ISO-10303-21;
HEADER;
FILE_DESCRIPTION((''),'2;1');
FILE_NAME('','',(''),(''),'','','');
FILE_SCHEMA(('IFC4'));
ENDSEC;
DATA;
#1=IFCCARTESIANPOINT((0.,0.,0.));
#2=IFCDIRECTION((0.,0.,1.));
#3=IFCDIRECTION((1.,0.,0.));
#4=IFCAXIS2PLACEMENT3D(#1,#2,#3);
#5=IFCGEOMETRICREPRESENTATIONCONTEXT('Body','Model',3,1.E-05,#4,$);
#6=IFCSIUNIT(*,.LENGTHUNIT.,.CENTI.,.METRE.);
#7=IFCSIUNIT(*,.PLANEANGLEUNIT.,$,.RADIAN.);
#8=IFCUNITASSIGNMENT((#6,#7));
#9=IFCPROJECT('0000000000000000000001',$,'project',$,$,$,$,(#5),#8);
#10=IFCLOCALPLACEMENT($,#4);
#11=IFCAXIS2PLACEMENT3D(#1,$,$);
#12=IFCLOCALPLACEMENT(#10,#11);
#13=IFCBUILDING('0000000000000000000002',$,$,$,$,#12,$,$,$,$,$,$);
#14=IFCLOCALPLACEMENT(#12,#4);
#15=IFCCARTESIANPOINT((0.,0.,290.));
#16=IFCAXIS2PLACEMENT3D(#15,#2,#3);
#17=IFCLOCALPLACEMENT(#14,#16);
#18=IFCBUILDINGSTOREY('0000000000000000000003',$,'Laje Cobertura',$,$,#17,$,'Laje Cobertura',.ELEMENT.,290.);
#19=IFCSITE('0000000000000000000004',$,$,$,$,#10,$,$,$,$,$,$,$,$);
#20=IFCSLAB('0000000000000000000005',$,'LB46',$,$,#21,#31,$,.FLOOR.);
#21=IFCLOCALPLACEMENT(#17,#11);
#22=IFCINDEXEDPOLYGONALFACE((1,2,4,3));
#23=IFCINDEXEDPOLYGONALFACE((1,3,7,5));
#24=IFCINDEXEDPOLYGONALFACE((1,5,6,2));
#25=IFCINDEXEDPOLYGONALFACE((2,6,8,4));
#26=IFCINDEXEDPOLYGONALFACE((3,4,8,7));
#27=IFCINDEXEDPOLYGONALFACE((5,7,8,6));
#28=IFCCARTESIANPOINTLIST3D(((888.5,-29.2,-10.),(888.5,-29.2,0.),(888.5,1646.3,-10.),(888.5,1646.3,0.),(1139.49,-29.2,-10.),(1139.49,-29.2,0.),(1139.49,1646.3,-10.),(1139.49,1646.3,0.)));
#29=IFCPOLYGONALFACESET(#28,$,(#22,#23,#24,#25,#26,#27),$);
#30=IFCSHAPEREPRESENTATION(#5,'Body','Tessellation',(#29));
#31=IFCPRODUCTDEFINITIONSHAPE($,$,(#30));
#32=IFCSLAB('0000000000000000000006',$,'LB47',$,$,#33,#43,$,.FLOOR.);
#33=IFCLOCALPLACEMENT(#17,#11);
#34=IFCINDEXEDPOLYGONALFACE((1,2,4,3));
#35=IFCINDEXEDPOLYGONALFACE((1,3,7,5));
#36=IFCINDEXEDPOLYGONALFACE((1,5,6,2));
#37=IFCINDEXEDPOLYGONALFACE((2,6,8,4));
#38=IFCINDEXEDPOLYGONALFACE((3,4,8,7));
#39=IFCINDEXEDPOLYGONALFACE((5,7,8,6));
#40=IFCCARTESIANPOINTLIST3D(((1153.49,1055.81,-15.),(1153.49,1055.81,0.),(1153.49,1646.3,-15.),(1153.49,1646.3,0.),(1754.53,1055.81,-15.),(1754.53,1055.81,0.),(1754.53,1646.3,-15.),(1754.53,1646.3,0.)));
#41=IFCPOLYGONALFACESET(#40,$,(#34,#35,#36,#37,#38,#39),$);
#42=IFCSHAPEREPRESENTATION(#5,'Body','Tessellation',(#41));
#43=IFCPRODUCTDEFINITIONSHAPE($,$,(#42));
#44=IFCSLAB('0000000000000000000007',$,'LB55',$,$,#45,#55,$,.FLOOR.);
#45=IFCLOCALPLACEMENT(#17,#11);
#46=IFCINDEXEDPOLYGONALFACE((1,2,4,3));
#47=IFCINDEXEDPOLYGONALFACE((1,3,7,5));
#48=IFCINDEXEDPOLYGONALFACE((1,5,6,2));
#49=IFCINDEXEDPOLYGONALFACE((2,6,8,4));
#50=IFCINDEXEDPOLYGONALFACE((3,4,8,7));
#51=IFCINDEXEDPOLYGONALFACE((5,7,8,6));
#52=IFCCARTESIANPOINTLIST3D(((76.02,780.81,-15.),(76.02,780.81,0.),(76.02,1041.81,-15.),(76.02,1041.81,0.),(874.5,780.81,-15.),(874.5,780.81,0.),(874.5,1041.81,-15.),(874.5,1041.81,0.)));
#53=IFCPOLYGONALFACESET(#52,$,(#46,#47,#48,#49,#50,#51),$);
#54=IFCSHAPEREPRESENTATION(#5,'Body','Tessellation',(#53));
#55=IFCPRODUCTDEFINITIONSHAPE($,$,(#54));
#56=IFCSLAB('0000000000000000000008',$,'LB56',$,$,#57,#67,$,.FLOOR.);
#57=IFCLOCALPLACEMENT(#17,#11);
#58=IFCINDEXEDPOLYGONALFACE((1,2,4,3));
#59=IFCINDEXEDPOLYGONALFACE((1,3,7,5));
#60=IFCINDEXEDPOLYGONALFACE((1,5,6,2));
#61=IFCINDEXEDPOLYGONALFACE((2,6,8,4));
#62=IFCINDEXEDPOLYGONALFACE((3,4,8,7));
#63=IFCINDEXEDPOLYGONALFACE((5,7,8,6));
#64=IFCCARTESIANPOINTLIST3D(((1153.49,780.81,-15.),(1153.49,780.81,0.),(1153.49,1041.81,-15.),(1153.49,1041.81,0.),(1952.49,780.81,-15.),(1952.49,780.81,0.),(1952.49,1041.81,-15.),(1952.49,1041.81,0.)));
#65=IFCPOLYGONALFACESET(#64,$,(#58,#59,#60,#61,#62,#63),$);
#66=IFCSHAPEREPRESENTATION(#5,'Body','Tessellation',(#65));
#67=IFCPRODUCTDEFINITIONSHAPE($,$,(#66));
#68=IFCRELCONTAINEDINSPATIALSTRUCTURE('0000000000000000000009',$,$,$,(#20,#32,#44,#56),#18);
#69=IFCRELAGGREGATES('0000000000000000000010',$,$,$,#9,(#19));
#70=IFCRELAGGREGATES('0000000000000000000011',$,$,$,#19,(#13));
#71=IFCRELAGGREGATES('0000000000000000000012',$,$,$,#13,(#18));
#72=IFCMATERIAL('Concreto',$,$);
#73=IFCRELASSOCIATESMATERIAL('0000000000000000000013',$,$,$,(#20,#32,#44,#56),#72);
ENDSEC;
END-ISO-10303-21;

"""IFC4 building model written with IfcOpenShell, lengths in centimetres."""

from ifc_helpers import new_model, si_unit, frame, origin, origin_with_axes, place, context, project, spatial, polyline, outline, extrude, material, element, save


model = new_model("IFC4")

# Units and contexts
model_context = context("Model", 3, precision=1e-05, world=origin_with_axes(), identifier="Body")
ifc_project = project(units=[si_unit("LENGTHUNIT", "METRE", prefix="CENTI"), si_unit("PLANEANGLEUNIT", "RADIAN")], contexts=[model_context])

# Site, building, storey
site_placement = place(None, origin_with_axes())
site = spatial("IfcSite", under=ifc_project, at=site_placement)
building_placement = place(site_placement, origin())
building = spatial("IfcBuilding", under=site, at=building_placement)
placement = place(building_placement, origin_with_axes())
storey_placement = place(placement, frame((0.0, 0.0, 290.0), z_axis=(0.0, 0.0, 1.0), x_axis=(1.0, 0.0, 0.0)))
storey = spatial("IfcBuildingStorey", under=building, at=storey_placement, Name="Laje Cobertura", LongName="Laje Cobertura", CompositionType="ELEMENT", Elevation=290.0)

# Shared definitions
ifc_material = material(Name="Concreto")

# Slabs
slab_1_placement = place(storey_placement, frame((1014.0, 808.55, 0.0), z_axis=(0.0, 0.0, 1.0), x_axis=(1.0, 0.0, 0.0)))
element("IfcSlab", 1, at=slab_1_placement, inside=storey, material=ifc_material, Name="LB46", PredefinedType="FLOOR", context=model_context, shape_type="SolidModel", body=[
    extrude(outline(polyline([(125.5, 837.75), (-125.5, 837.75), (-125.49, -837.75), (125.5, -837.75), (125.5, 837.75), (125.5, 837.75)])), frame((0.0, 0.0, -10.0), z_axis=(0.0, 0.0, 1.0), x_axis=(1.0, 0.0, 0.0)), (0.0, 0.0, 1.0), 10.0),
])
slab_2_placement = place(storey_placement, frame((1454.01, 1351.05, 0.0), z_axis=(0.0, 0.0, 1.0), x_axis=(1.0, 0.0, 0.0)))
element("IfcSlab", 2, at=slab_2_placement, inside=storey, material=ifc_material, Name="LB47", PredefinedType="FLOOR", context=model_context, shape_type="SolidModel", body=[
    extrude(outline(polyline([(300.52, -295.25), (300.52, 295.24), (-300.52, 295.24), (-300.52, -295.24), (300.52, -295.25), (300.52, -295.25)])), frame((0.0, 0.0, -15.0), z_axis=(0.0, 0.0, 1.0), x_axis=(1.0, 0.0, 0.0)), (0.0, 0.0, 1.0), 15.0),
])
slab_3_placement = place(storey_placement, frame((475.26, 911.31, 0.0), z_axis=(0.0, 0.0, 1.0), x_axis=(1.0, 0.0, 0.0)))
element("IfcSlab", 3, at=slab_3_placement, inside=storey, material=ifc_material, Name="LB55", PredefinedType="FLOOR", context=model_context, shape_type="SolidModel", body=[
    extrude(outline(polyline([(399.24, 130.5), (-399.24, 130.5), (-399.24, -130.5), (399.24, -130.5), (399.24, 130.5), (399.24, 130.5)])), frame((0.0, 0.0, -15.0), z_axis=(0.0, 0.0, 1.0), x_axis=(1.0, 0.0, 0.0)), (0.0, 0.0, 1.0), 15.0),
])
slab_4_placement = place(storey_placement, frame((1552.99, 911.31, 0.0), z_axis=(0.0, 0.0, 1.0), x_axis=(1.0, 0.0, 0.0)))
element("IfcSlab", 4, at=slab_4_placement, inside=storey, material=ifc_material, Name="LB56", PredefinedType="FLOOR", context=model_context, shape_type="SolidModel", body=[
    extrude(outline(polyline([(399.5, -130.5), (399.5, 130.5), (-399.5, 130.5), (-399.5, -130.5), (399.5, -130.5), (399.5, -130.5)])), frame((0.0, 0.0, -15.0), z_axis=(0.0, 0.0, 1.0), x_axis=(1.0, 0.0, 0.0)), (0.0, 0.0, 1.0), 15.0),
])

save(model, "model.ifc")
